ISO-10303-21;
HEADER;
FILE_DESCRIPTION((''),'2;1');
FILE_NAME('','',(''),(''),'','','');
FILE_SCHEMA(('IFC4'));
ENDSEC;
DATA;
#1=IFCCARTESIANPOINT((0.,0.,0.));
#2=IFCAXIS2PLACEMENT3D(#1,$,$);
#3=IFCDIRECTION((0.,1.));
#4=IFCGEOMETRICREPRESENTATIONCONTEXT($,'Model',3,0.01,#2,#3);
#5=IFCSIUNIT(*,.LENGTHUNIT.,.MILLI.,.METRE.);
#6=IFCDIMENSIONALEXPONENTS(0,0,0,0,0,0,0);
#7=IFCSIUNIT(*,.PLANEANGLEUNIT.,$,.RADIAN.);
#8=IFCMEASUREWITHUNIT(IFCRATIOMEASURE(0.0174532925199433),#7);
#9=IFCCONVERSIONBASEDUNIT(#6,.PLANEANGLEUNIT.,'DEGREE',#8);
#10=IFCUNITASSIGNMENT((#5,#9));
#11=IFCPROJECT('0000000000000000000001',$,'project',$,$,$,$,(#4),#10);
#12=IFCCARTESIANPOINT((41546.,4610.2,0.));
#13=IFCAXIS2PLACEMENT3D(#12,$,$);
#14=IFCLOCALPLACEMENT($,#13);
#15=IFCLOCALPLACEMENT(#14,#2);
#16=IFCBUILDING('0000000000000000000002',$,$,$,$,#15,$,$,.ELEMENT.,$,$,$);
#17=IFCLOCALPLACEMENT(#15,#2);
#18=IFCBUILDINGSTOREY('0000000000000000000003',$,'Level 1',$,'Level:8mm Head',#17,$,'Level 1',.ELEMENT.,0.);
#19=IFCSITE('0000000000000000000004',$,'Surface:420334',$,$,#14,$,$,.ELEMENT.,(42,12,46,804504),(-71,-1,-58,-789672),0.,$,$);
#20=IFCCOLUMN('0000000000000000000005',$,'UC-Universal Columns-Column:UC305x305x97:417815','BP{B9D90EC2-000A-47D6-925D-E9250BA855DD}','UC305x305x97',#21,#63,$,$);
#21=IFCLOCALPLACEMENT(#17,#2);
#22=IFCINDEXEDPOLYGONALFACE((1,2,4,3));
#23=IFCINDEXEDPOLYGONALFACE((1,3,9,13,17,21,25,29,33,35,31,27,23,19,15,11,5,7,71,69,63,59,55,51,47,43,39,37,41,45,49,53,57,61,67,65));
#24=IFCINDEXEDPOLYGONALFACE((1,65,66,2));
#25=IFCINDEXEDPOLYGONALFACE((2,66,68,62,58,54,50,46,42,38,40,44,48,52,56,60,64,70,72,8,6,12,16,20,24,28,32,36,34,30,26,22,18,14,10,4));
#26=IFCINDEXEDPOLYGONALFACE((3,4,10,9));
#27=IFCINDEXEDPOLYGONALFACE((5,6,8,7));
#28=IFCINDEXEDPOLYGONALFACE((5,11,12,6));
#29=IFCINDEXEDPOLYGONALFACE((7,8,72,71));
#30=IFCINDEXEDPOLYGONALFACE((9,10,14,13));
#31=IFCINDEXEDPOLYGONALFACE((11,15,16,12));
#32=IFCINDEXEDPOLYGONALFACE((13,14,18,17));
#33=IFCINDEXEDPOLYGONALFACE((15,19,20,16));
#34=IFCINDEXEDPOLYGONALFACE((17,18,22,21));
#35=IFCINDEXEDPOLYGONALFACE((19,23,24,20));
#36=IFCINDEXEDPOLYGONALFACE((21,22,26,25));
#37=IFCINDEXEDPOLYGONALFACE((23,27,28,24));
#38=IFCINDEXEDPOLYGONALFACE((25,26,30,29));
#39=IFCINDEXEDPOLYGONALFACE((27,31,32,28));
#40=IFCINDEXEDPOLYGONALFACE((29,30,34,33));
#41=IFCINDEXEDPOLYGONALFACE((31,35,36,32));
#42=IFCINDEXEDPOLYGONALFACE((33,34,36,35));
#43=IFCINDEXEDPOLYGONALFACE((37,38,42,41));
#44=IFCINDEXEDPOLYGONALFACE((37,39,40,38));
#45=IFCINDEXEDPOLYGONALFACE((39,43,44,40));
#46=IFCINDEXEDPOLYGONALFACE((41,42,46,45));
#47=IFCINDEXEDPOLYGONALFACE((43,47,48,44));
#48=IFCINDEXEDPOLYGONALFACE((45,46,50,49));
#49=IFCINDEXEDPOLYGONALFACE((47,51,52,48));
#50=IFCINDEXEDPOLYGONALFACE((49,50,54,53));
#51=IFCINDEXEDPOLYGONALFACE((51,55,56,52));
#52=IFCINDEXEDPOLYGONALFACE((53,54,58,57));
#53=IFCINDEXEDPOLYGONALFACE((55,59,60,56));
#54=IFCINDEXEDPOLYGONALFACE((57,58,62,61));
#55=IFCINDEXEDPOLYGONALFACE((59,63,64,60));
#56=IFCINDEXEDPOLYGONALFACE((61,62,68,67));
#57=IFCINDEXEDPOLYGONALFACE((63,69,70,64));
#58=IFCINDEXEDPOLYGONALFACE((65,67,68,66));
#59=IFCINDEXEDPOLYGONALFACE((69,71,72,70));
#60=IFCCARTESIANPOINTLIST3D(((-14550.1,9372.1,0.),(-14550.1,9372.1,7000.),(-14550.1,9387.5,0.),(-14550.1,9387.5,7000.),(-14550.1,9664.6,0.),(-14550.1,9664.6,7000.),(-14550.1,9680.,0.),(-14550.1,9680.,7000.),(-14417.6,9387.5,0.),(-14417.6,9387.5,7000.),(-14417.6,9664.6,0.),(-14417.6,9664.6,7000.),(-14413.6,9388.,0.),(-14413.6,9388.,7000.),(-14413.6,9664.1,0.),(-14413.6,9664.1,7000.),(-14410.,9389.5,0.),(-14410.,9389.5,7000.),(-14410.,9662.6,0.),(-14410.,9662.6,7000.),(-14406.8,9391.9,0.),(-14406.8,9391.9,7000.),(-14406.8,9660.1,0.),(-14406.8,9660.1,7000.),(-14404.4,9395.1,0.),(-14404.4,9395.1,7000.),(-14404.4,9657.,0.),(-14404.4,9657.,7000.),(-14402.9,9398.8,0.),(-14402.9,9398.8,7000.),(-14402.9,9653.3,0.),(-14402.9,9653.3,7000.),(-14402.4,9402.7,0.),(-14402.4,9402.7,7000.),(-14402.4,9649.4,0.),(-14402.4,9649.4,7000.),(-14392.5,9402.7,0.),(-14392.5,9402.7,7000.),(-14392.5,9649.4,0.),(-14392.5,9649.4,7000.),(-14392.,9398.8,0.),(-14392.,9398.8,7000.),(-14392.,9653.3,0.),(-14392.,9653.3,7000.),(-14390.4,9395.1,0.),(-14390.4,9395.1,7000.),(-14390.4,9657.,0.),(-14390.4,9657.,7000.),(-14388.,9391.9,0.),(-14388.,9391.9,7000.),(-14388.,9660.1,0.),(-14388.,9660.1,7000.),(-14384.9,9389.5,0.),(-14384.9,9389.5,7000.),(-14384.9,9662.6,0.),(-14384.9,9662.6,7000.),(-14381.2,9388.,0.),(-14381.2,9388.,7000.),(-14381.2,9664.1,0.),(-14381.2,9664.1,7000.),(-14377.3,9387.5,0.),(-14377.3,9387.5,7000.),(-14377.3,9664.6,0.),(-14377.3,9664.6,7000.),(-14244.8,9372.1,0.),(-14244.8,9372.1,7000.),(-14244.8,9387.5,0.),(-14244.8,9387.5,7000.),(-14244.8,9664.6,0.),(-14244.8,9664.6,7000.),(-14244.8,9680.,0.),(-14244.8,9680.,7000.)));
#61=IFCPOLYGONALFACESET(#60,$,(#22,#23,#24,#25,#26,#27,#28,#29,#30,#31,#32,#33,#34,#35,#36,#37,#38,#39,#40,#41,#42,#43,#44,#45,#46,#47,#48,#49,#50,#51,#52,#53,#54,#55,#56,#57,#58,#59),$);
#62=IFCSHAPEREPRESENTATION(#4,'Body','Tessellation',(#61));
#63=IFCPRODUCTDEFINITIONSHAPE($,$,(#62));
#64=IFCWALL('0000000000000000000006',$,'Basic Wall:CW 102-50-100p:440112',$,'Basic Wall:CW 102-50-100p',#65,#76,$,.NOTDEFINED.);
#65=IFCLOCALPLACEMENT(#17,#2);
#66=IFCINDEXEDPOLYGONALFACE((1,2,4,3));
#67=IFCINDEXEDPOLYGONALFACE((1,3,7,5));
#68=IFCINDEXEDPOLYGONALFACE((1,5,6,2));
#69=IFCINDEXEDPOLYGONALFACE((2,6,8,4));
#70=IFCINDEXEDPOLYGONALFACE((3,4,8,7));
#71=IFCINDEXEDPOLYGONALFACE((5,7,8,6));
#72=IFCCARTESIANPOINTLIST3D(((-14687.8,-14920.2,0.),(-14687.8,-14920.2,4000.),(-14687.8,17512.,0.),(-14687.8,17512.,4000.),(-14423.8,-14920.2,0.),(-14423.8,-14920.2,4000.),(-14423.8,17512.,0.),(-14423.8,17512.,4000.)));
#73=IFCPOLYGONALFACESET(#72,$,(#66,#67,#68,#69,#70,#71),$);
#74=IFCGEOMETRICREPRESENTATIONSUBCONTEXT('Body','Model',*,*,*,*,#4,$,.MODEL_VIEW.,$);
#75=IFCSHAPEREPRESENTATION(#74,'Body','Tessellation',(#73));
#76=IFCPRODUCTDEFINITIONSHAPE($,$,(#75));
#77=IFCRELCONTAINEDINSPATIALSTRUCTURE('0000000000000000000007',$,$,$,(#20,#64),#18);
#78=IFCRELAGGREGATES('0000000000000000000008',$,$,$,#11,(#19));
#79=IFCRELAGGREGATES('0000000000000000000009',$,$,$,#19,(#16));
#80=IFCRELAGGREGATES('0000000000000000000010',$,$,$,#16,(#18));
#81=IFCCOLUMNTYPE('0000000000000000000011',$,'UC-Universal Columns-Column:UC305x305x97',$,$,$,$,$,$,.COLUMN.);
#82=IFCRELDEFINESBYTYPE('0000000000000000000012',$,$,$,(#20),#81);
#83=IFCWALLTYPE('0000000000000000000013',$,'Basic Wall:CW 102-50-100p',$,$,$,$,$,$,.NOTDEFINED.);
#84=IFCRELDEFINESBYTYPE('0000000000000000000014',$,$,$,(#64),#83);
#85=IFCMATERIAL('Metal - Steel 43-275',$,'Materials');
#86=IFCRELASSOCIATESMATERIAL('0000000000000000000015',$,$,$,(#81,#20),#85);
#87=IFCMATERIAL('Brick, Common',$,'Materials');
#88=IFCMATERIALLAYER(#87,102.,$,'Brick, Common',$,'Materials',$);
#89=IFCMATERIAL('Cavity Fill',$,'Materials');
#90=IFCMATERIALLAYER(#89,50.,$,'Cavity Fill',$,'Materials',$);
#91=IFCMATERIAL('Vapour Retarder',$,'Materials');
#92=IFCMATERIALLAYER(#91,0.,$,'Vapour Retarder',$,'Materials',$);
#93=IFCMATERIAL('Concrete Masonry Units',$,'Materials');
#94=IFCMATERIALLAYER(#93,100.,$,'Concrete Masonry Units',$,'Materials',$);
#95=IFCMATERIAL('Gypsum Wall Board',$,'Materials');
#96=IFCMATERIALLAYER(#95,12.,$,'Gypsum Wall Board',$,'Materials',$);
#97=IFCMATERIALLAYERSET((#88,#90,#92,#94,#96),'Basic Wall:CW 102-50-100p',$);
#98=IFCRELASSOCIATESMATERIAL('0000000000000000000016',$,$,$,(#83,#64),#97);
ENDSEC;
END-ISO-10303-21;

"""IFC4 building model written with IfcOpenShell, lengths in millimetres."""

from ifc_helpers import new_model, entity, si_unit, converted_unit, direction, frame, frame_2d, origin, origin_2d, place, context, subcontext, project, spatial, rectangle, i_section, extrude, material, layer, layer_set, layer_usage, type_object, element, save


model = new_model("IFC4")

# Units and contexts
model_context = context("Model", 3, precision=0.01, world=origin(), true_north=direction((0.0, 1.0)))
body_context = subcontext(model_context, "Body", "Model", "MODEL_VIEW")
ifc_project = project(units=[si_unit("LENGTHUNIT", "METRE", prefix="MILLI"), converted_unit("PLANEANGLEUNIT", "DEGREE", entity("IfcRatioMeasure", 0.0174532925199433), si_unit("PLANEANGLEUNIT", "RADIAN"), dimensions=[0, 0, 0, 0, 0, 0, 0])], contexts=[model_context])

# Site, building, storey
site_placement = place(None, frame((41546.0, 4610.2, 0.0)))
site = spatial("IfcSite", under=ifc_project, at=site_placement, Name="Surface:420334", CompositionType="ELEMENT", RefLatitude=(42, 12, 46, 804504), RefLongitude=(-71, -1, -58, -789672), RefElevation=0.0)
building_placement = place(site_placement, origin())
building = spatial("IfcBuilding", under=site, at=building_placement, CompositionType="ELEMENT")
storey_placement = place(building_placement, origin())
storey = spatial("IfcBuildingStorey", under=building, at=storey_placement, Name="Level 1", ObjectType="Level:8mm Head", LongName="Level 1", CompositionType="ELEMENT", Elevation=0.0)

# Column
ifc_material_1 = material(Name="Metal - Steel 43-275", Category="Materials")
column_type = type_object("IfcColumnType", Name="UC-Universal Columns-Column:UC305x305x97", PredefinedType="COLUMN", material=ifc_material_1)
column_1_placement = place(storey_placement, frame((-14397.4, 9526.0, 7000.0)))
element("IfcColumn", 1, at=column_1_placement, inside=storey, type_object=column_type, material=ifc_material_1, Name="UC-Universal Columns-Column:UC305x305x97:417815", Description="BP{B9D90EC2-000A-47D6-925D-E9250BA855DD}", ObjectType="UC305x305x97", context=model_context, shape_type="SweptSolid", body=[
    extrude(i_section(OverallWidth=305.3, OverallDepth=307.9, WebThickness=9.9, FlangeThickness=15.4, FilletRadius=15.2, at=origin_2d()), origin(), (0.0, 0.0, -1.0), 7000.0),
])

# Wall
ifc_material_2 = material(Name="Brick, Common", Category="Materials")
ifc_layer_1 = layer(ifc_material_2, 102.0, Name="Brick, Common", Category="Materials")
ifc_material_3 = material(Name="Cavity Fill", Category="Materials")
ifc_layer_2 = layer(ifc_material_3, 50.0, Name="Cavity Fill", Category="Materials")
ifc_material_4 = material(Name="Vapour Retarder", Category="Materials")
ifc_layer_3 = layer(ifc_material_4, 0.0, Name="Vapour Retarder", Category="Materials")
ifc_material_5 = material(Name="Concrete Masonry Units", Category="Materials")
ifc_layer_4 = layer(ifc_material_5, 100.0, Name="Concrete Masonry Units", Category="Materials")
ifc_material_6 = material(Name="Gypsum Wall Board", Category="Materials")
ifc_layer_5 = layer(ifc_material_6, 12.0, Name="Gypsum Wall Board", Category="Materials")
ifc_layer_set = layer_set([ifc_layer_1, ifc_layer_2, ifc_layer_3, ifc_layer_4, ifc_layer_5], Name="Basic Wall:CW 102-50-100p")
ifc_layer_usage = layer_usage(ifc_layer_set, "AXIS2", "NEGATIVE", 132.0)
wall_type = type_object("IfcWallType", Name="Basic Wall:CW 102-50-100p", PredefinedType="NOTDEFINED", material=ifc_layer_set)
wall_placement = place(storey_placement, frame((-14555.8, 17512.0, 0.0), z_axis=(0.0, 0.0, 1.0), x_axis=(0.0, -1.0, 0.0)))
element("IfcWall", 2, at=wall_placement, inside=storey, type_object=wall_type, material=ifc_layer_usage, Name="Basic Wall:CW 102-50-100p:440112", ObjectType="Basic Wall:CW 102-50-100p", PredefinedType="NOTDEFINED", context=body_context, shape_type="SweptSolid", body=[
    extrude(rectangle(XDim=32432.2, YDim=264.0, at=frame_2d((16216.1, 0.0), x_axis=(-1.0, 0.0))), origin(), (0.0, 0.0, 1.0), 4000.0),
])

save(model, "model.ifc")
